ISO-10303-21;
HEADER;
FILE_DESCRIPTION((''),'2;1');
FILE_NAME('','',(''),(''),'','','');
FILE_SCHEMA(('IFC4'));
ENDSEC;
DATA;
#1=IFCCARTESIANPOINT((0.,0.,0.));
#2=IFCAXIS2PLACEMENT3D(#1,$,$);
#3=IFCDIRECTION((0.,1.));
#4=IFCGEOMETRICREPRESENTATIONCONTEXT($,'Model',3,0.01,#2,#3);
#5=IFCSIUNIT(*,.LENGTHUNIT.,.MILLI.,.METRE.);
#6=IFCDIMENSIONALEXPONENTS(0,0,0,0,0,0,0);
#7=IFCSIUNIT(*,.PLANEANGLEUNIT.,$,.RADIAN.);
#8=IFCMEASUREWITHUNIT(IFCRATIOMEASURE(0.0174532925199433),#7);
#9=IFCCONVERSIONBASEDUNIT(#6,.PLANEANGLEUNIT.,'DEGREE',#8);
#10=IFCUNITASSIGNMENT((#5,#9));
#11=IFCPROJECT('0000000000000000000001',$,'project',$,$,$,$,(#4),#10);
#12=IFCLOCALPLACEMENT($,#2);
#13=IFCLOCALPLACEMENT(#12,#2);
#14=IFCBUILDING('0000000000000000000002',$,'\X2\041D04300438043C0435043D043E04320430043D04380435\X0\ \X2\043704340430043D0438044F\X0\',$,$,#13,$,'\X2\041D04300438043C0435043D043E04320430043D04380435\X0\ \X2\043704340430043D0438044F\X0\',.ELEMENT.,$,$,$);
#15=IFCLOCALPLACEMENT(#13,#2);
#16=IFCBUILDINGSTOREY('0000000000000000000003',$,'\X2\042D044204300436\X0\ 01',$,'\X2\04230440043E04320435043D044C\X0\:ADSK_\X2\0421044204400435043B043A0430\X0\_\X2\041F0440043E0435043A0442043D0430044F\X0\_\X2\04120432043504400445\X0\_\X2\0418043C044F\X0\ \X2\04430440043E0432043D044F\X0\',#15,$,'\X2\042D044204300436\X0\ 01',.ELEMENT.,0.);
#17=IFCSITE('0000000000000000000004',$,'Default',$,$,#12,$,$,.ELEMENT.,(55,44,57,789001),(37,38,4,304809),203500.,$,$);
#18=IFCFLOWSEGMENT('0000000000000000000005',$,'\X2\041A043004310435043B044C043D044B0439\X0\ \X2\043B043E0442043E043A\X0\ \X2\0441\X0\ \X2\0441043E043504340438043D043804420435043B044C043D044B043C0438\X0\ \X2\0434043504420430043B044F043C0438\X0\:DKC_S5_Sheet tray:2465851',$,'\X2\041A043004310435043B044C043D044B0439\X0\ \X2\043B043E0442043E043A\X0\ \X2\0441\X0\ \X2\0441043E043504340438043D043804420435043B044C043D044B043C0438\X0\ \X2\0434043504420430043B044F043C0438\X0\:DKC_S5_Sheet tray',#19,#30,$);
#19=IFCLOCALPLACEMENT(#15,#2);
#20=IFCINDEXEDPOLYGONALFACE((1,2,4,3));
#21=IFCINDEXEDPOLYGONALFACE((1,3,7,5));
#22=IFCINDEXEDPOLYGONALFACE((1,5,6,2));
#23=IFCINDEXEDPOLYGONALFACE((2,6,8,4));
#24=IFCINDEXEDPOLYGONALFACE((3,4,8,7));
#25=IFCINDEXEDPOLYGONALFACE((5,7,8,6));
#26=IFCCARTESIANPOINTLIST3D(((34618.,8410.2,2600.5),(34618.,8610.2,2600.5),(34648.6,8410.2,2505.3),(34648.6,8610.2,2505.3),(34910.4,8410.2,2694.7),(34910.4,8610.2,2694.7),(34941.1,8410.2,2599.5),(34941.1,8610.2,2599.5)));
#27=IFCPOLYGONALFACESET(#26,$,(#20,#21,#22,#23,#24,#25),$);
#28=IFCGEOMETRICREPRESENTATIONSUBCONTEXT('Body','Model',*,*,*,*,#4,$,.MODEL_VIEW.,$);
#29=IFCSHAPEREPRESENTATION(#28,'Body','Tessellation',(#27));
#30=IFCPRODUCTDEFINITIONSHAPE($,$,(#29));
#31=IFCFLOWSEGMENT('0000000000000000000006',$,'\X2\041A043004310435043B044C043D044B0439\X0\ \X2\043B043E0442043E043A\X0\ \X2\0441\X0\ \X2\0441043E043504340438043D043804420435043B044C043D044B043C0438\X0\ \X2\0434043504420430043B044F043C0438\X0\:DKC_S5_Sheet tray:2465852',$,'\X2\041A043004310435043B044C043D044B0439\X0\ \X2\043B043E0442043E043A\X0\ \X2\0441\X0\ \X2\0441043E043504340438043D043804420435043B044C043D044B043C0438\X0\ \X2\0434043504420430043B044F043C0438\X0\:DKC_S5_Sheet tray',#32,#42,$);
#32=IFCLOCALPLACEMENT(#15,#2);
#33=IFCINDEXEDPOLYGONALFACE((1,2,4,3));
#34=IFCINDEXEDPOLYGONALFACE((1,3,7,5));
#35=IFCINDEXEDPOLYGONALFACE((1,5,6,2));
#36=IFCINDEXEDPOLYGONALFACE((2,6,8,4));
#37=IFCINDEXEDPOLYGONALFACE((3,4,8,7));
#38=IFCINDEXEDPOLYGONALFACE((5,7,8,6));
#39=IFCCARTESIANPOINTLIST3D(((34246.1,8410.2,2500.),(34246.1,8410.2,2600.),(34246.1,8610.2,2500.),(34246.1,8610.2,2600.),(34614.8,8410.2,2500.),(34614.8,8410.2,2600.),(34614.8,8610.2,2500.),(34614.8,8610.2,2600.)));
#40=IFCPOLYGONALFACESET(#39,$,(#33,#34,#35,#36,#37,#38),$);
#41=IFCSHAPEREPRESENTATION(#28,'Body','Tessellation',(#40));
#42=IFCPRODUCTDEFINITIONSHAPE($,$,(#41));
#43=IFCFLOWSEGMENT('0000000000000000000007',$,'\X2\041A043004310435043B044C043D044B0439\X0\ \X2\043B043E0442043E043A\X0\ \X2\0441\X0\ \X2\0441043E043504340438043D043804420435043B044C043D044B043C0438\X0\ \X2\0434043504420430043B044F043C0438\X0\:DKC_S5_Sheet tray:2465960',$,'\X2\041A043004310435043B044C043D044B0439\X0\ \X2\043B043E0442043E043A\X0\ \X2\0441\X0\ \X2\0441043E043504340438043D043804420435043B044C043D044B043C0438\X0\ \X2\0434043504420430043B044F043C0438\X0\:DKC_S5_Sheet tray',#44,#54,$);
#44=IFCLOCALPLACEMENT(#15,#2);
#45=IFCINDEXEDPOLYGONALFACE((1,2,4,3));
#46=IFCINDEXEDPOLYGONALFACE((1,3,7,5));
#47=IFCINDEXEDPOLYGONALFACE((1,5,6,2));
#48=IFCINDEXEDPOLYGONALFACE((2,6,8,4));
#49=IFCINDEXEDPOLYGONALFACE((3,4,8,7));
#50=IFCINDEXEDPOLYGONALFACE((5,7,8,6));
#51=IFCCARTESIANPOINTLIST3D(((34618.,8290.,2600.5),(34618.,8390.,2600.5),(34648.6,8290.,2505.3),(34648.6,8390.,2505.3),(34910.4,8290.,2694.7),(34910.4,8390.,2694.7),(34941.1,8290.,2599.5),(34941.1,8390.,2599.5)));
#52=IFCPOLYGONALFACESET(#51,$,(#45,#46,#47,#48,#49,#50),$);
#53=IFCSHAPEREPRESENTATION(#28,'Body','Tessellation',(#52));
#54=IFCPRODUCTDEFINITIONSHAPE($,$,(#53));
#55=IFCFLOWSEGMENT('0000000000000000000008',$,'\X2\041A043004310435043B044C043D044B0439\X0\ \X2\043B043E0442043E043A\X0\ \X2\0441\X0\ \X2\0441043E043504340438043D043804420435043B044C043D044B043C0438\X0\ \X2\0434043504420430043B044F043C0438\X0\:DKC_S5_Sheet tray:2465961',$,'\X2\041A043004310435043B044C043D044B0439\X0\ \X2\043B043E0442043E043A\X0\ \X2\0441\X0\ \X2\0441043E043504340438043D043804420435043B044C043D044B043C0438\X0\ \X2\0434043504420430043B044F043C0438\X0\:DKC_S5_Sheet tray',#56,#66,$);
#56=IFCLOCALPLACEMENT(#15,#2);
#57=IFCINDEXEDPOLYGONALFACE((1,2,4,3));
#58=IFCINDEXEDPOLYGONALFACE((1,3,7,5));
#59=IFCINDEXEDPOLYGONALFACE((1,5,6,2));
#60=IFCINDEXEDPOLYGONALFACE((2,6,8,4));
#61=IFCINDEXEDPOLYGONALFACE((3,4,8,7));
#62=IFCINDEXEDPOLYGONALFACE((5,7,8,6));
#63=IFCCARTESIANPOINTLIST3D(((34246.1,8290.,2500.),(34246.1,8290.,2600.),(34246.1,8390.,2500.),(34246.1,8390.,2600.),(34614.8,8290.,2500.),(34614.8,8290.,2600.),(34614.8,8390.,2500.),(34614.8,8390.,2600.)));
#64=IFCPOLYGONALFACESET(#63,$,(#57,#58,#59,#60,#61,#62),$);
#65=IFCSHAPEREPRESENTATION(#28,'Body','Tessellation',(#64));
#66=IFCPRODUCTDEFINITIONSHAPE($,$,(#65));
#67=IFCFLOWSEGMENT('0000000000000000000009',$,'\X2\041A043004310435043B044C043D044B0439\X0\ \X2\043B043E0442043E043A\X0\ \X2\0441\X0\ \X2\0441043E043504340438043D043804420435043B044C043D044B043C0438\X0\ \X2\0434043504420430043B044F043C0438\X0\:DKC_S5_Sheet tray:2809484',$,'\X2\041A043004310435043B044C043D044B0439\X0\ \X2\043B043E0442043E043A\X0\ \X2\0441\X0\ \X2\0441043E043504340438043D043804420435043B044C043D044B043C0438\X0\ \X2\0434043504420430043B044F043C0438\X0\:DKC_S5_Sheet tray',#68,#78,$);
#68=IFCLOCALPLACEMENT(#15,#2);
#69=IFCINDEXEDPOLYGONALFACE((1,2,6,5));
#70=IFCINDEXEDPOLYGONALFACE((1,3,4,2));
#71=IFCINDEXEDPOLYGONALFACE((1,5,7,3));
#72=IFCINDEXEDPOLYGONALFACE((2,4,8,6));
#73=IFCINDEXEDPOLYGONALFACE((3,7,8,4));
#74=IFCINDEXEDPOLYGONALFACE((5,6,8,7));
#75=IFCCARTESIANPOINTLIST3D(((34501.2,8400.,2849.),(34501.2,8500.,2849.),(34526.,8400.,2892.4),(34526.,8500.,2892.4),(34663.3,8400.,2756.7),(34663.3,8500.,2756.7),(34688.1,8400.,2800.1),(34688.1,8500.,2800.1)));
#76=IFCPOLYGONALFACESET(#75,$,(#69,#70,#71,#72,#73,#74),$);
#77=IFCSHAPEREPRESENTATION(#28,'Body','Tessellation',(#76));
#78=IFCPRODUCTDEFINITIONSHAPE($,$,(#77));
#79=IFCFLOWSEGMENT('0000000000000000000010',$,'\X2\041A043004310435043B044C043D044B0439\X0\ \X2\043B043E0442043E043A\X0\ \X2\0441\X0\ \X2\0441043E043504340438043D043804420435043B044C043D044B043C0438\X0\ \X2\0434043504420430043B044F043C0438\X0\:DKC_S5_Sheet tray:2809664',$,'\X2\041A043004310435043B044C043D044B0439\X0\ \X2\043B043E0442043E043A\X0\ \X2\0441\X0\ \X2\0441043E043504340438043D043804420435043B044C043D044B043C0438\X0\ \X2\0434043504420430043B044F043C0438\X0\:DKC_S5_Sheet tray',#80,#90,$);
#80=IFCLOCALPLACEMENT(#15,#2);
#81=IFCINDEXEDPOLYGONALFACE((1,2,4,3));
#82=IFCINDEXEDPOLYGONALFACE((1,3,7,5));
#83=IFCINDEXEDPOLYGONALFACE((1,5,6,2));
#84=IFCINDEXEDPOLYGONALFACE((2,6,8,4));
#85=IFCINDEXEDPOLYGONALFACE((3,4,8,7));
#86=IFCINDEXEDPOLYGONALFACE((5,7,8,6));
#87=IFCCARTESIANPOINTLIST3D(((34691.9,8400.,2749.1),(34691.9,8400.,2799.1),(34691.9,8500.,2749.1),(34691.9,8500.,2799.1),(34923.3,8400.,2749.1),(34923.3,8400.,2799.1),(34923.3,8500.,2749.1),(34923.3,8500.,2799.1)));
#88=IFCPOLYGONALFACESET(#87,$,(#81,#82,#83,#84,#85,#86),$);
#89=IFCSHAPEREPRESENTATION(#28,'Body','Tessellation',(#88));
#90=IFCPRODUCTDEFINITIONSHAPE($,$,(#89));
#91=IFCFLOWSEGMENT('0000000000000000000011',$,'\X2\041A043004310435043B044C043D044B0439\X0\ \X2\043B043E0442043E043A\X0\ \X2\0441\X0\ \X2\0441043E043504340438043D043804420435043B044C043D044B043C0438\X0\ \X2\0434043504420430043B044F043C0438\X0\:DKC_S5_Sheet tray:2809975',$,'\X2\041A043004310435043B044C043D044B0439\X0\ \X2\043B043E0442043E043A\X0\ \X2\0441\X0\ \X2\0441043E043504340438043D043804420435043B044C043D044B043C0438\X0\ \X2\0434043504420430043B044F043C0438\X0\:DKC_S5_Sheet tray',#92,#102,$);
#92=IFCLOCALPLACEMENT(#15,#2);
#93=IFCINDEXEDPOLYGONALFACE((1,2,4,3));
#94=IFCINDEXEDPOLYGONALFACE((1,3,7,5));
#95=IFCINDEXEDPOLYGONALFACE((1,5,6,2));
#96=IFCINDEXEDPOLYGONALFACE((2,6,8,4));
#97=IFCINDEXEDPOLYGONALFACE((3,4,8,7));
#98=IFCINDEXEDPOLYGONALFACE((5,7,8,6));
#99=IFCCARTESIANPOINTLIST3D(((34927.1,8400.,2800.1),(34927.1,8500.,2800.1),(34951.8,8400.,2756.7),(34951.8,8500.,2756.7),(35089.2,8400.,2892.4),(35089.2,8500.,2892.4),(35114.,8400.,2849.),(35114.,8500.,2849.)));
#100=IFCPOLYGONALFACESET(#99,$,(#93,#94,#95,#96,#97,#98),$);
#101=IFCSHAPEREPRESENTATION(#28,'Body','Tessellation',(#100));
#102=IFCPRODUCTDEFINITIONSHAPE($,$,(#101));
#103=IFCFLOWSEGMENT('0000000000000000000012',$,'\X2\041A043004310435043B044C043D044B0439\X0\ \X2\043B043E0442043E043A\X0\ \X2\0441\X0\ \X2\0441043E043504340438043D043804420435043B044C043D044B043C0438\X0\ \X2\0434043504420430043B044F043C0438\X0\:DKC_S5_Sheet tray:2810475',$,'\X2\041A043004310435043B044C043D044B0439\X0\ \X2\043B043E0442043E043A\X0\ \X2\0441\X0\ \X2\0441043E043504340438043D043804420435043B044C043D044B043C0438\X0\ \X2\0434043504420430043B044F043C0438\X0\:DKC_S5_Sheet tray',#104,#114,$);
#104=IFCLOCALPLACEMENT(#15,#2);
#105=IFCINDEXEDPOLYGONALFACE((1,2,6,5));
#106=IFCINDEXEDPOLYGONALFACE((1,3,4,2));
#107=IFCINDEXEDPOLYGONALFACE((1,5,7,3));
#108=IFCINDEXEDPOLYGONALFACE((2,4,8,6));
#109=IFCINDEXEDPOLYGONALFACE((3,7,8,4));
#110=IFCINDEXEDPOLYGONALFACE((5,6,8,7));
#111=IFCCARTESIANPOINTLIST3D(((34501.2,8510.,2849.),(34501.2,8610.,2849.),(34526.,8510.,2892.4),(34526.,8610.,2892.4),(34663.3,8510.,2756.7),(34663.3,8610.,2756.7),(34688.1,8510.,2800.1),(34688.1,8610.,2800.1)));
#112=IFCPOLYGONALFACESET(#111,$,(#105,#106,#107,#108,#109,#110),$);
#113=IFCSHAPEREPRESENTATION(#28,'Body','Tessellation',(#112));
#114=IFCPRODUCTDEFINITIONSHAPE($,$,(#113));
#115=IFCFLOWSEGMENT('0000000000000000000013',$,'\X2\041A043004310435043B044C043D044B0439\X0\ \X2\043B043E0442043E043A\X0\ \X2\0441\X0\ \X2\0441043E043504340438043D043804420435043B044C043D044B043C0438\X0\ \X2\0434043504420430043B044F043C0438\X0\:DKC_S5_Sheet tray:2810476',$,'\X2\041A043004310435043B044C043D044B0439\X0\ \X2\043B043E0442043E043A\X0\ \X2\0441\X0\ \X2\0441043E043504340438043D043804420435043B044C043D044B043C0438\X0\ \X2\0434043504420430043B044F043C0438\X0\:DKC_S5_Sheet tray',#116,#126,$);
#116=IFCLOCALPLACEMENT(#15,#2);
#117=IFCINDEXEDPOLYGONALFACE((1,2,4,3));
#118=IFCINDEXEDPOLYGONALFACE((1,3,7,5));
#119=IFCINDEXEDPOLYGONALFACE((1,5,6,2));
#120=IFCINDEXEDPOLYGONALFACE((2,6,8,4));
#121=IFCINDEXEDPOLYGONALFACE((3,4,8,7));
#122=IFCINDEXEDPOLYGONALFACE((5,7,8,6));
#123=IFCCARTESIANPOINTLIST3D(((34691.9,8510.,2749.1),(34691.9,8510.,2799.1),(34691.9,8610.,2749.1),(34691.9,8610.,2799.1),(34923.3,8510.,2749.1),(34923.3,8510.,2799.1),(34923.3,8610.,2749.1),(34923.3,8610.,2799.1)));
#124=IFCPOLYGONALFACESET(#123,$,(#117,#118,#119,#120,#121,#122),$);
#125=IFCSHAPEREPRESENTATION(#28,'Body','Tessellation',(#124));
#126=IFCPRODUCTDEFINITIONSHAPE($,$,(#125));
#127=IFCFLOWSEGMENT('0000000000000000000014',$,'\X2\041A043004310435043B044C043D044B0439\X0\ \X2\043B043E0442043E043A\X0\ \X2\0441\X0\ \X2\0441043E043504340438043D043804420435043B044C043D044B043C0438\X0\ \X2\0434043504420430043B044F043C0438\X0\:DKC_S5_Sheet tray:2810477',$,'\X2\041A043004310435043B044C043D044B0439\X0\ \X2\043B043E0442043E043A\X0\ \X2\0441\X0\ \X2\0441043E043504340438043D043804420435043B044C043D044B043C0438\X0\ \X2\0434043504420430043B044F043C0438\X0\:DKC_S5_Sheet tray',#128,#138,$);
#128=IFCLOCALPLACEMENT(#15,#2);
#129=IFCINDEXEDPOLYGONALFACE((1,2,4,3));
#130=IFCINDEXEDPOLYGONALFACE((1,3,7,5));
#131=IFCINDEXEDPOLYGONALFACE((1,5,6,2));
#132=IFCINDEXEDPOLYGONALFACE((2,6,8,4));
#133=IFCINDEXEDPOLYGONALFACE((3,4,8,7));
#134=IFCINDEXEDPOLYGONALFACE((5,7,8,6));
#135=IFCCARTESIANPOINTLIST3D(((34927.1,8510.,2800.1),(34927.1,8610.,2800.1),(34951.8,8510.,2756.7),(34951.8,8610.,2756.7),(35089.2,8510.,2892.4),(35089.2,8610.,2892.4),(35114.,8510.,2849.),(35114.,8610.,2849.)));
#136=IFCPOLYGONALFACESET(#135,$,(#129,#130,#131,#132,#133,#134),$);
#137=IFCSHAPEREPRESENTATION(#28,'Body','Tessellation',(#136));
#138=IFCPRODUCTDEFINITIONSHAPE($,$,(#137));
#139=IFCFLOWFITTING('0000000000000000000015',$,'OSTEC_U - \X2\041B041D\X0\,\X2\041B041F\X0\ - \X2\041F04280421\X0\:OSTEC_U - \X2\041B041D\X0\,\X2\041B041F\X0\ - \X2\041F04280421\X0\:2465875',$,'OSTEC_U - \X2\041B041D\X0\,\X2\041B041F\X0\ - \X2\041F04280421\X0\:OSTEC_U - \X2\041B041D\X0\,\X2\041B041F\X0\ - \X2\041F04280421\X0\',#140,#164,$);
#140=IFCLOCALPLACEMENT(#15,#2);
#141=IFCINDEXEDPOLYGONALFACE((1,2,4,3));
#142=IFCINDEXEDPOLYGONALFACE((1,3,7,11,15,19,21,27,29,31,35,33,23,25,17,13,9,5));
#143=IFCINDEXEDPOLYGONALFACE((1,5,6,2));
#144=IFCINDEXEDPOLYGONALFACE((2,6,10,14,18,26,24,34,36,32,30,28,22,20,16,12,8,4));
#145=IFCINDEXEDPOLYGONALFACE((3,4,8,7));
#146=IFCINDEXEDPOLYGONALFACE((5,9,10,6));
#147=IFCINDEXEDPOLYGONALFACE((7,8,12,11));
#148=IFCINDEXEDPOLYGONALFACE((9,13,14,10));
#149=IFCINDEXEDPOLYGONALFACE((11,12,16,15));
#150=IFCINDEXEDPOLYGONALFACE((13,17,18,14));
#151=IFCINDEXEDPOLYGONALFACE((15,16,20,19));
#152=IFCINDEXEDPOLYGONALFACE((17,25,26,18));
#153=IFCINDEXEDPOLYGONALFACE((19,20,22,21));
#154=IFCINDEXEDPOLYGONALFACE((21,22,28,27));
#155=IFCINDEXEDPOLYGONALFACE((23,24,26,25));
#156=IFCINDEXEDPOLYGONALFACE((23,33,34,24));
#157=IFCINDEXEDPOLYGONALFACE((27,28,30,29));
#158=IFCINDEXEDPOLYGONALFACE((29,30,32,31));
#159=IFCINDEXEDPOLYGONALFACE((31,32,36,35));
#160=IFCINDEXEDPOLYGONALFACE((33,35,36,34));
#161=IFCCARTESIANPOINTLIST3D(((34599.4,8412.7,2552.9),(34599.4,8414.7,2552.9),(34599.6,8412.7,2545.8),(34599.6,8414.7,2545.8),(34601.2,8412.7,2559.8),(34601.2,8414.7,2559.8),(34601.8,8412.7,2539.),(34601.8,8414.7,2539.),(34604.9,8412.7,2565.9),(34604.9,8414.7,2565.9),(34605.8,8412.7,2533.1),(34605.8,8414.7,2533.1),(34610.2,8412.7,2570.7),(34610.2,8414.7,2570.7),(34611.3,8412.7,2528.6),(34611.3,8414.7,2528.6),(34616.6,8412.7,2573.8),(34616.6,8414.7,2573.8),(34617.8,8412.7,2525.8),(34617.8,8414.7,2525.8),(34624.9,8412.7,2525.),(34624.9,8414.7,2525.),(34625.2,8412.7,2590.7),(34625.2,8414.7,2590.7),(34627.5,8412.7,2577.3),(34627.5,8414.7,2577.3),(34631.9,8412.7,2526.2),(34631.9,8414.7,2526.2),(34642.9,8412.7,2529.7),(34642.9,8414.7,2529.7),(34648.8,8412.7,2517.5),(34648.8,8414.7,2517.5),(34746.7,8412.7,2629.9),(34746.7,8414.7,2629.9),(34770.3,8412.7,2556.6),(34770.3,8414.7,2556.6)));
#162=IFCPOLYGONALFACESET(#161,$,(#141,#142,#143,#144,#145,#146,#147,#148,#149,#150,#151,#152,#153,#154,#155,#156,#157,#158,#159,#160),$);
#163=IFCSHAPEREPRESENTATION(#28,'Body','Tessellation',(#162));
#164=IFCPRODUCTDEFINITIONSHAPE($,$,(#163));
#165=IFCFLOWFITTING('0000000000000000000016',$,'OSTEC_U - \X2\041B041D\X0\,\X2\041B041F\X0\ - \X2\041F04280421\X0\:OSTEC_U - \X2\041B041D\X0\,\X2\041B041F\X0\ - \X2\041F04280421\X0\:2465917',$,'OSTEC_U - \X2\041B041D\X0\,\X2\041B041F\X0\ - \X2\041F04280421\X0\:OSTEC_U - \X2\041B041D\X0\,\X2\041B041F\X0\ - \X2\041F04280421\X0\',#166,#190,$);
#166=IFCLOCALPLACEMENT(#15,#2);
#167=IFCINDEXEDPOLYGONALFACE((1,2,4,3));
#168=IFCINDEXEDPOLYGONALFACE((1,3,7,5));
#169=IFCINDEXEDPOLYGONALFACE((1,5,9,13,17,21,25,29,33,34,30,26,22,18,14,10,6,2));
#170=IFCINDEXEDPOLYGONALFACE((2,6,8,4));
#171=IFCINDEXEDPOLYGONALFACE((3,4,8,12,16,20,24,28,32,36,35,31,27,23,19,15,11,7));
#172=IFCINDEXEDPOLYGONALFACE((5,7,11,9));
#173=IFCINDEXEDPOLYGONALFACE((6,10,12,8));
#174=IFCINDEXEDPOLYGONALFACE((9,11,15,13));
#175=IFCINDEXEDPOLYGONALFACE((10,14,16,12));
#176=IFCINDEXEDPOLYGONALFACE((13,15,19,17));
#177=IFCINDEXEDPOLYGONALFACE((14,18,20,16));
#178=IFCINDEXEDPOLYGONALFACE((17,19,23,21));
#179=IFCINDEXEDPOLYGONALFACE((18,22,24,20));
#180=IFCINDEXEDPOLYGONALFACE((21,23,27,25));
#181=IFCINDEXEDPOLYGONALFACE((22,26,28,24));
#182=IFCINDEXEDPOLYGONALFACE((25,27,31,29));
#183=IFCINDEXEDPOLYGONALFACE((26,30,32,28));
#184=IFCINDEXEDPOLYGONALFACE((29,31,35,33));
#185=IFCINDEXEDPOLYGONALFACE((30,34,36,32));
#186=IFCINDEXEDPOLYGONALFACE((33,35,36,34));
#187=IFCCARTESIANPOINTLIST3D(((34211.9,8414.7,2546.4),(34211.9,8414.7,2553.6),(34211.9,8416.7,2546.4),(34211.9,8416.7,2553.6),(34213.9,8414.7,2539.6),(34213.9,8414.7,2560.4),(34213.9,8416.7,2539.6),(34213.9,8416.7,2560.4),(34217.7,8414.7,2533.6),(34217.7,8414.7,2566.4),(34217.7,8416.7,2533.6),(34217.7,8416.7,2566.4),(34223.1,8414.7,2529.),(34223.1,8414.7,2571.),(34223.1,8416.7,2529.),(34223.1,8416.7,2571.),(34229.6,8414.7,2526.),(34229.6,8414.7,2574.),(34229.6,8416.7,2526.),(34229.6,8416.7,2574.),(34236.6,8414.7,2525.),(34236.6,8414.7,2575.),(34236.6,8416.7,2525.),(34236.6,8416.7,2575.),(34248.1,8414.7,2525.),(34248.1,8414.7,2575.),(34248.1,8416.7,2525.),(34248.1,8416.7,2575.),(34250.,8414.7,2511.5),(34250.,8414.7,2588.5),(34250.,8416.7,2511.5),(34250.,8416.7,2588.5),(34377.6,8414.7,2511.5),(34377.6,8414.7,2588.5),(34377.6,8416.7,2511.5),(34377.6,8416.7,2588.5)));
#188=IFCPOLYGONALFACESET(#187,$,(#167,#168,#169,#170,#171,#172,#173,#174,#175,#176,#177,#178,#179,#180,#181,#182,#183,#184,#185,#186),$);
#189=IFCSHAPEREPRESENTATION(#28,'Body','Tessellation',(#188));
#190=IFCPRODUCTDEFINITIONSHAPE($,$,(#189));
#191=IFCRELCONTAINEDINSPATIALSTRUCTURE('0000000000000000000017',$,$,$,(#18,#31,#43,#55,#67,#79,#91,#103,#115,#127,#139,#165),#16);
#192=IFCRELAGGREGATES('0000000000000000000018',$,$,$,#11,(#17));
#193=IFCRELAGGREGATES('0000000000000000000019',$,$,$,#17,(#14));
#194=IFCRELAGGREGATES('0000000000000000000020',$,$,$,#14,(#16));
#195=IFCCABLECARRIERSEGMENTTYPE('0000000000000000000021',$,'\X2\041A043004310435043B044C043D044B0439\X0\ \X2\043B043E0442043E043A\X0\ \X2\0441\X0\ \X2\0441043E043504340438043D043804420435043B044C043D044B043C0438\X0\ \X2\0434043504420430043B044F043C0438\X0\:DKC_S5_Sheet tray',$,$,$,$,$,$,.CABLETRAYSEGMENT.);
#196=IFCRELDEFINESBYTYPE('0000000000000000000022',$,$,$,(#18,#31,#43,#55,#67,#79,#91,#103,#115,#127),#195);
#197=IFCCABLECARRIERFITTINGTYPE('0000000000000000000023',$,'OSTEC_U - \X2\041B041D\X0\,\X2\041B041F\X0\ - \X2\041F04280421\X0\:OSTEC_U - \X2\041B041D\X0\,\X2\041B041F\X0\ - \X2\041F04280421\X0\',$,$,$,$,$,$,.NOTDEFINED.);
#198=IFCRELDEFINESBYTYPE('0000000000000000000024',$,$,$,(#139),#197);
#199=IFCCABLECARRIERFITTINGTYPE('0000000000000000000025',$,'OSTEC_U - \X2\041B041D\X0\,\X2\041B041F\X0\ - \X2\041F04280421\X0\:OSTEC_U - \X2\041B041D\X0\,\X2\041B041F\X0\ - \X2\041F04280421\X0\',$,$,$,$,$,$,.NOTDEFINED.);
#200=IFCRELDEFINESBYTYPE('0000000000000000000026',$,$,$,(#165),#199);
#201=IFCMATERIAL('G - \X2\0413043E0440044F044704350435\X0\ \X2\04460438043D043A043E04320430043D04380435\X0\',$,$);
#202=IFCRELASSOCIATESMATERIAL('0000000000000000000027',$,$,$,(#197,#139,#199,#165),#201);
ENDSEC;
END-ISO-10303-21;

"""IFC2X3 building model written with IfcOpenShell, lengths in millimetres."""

from ifc_helpers import new_model, entity, si_unit, converted_unit, direction, frame, frame_2d, origin, origin_2d_with_axis, place, context, subcontext, project, spatial, polyline, circle_curve, parameter, trimmed, segment, composite_curve, rectangle, outline, extrude, source, transform, mapped, material, type_object, type_shapes, element, save


model = new_model("IFC2X3")

# Units and contexts
model_context = context("Model", 3, precision=0.01, world=origin(), true_north=direction((0.0, 1.0)))
body_context = subcontext(model_context, "Body", "Model", "MODEL_VIEW")
ifc_project = project(units=[si_unit("LENGTHUNIT", "METRE", prefix="MILLI"), converted_unit("PLANEANGLEUNIT", "DEGREE", entity("IfcRatioMeasure", 0.0174532925199433), si_unit("PLANEANGLEUNIT", "RADIAN"), dimensions=[0, 0, 0, 0, 0, 0, 0])], contexts=[model_context])

# Site, building, storey
site_placement = place(None, origin())
site = spatial("IfcSite", under=ifc_project, at=site_placement, Name="Default", CompositionType="ELEMENT", RefLatitude=(55, 44, 57, 789001), RefLongitude=(37, 38, 4, 304809), RefElevation=203500.0)
building_placement = place(site_placement, origin())
building = spatial("IfcBuilding", under=site, at=building_placement, Name="Наименование здания", LongName="Наименование здания", CompositionType="ELEMENT")
storey_placement = place(building_placement, origin())
storey = spatial("IfcBuildingStorey", under=building, at=storey_placement, Name="Этаж 01", ObjectType="Уровень:ADSK_Стрелка_Проектная_Вверх_Имя уровня", LongName="Этаж 01", CompositionType="ELEMENT", Elevation=0.0)

# Flow segments
cable_carrier_segment_type = type_object("IfcCableCarrierSegmentType", Name="Кабельный лоток с соединительными деталями:DKC_S5_Sheet tray", PredefinedType="CABLETRAYSEGMENT")
flow_segment_1_placement = place(storey_placement, frame((34617.9, 8410.2, 2505.3)))
element("IfcFlowSegment", 1, at=flow_segment_1_placement, inside=storey, type_object=cable_carrier_segment_type, Name="Кабельный лоток с соединительными деталями:DKC_S5_Sheet tray:2465851", ObjectType="Кабельный лоток с соединительными деталями:DKC_S5_Sheet tray", context=body_context, shape_type="SweptSolid", body=[
    extrude(rectangle(XDim=100.0, YDim=200.0, at=origin_2d_with_axis()), frame((15.3, 100.0, 47.6), z_axis=(0.951851, 0.0, 0.30656), x_axis=(-0.30656, 0.0, 0.951851)), (0.0, 0.0, 1.0), 307.2),
])
flow_segment_2_placement = place(storey_placement, frame((34246.1, 8410.2, 2500.0)))
element("IfcFlowSegment", 2, at=flow_segment_2_placement, inside=storey, type_object=cable_carrier_segment_type, Name="Кабельный лоток с соединительными деталями:DKC_S5_Sheet tray:2465852", ObjectType="Кабельный лоток с соединительными деталями:DKC_S5_Sheet tray", context=body_context, shape_type="SweptSolid", body=[
    extrude(rectangle(XDim=368.7, YDim=200.0, at=origin_2d_with_axis()), frame((184.3, 100.0, 0.0), z_axis=(0.0, 0.0, 1.0), x_axis=(-1.0, 0.0, 0.0)), (0.0, 0.0, 1.0), 100.0),
])
flow_segment_3_placement = place(storey_placement, frame((34617.9, 8290.0, 2505.3)))
element("IfcFlowSegment", 3, at=flow_segment_3_placement, inside=storey, type_object=cable_carrier_segment_type, Name="Кабельный лоток с соединительными деталями:DKC_S5_Sheet tray:2465960", ObjectType="Кабельный лоток с соединительными деталями:DKC_S5_Sheet tray", context=body_context, shape_type="SweptSolid", body=[
    extrude(rectangle(XDim=100.0, YDim=100.0, at=origin_2d_with_axis()), frame((15.3, 50.0, 47.6), z_axis=(0.951851, 0.0, 0.30656), x_axis=(-0.30656, 0.0, 0.951851)), (0.0, 0.0, 1.0), 307.2),
])
flow_segment_4_placement = place(storey_placement, frame((34246.1, 8290.0, 2500.0)))
element("IfcFlowSegment", 4, at=flow_segment_4_placement, inside=storey, type_object=cable_carrier_segment_type, Name="Кабельный лоток с соединительными деталями:DKC_S5_Sheet tray:2465961", ObjectType="Кабельный лоток с соединительными деталями:DKC_S5_Sheet tray", context=body_context, shape_type="SweptSolid", body=[
    extrude(rectangle(XDim=368.7, YDim=100.0, at=origin_2d_with_axis()), frame((184.3, 50.0, 0.0), z_axis=(0.0, 0.0, 1.0), x_axis=(-1.0, 0.0, 0.0)), (0.0, 0.0, 1.0), 100.0),
])
flow_segment_5_placement = place(storey_placement, frame((34501.2, 8400.0, 2756.7)))
element("IfcFlowSegment", 5, at=flow_segment_5_placement, inside=storey, type_object=cable_carrier_segment_type, Name="Кабельный лоток с соединительными деталями:DKC_S5_Sheet tray:2809484", ObjectType="Кабельный лоток с соединительными деталями:DKC_S5_Sheet tray", context=body_context, shape_type="SweptSolid", body=[
    extrude(rectangle(XDim=50.0, YDim=100.0, at=frame_2d((0.0, 0.0), x_axis=(0.0, 1.0))), frame((12.4, 50.0, 114.0), z_axis=(0.869016, 0.0, -0.494783), x_axis=(0.0, 1.0, 0.0)), (0.0, 0.0, 1.0), 186.6),
])
flow_segment_6_placement = place(storey_placement, frame((34691.9, 8400.0, 2749.1)))
element("IfcFlowSegment", 6, at=flow_segment_6_placement, inside=storey, type_object=cable_carrier_segment_type, Name="Кабельный лоток с соединительными деталями:DKC_S5_Sheet tray:2809664", ObjectType="Кабельный лоток с соединительными деталями:DKC_S5_Sheet tray", context=body_context, shape_type="SweptSolid", body=[
    extrude(rectangle(XDim=231.3, YDim=100.0, at=origin_2d_with_axis()), frame((115.7, 50.0, 0.0)), (0.0, 0.0, 1.0), 50.0),
])
flow_segment_7_placement = place(storey_placement, frame((34927.1, 8400.0, 2756.7)))
element("IfcFlowSegment", 7, at=flow_segment_7_placement, inside=storey, type_object=cable_carrier_segment_type, Name="Кабельный лоток с соединительными деталями:DKC_S5_Sheet tray:2809975", ObjectType="Кабельный лоток с соединительными деталями:DKC_S5_Sheet tray", context=body_context, shape_type="SweptSolid", body=[
    extrude(rectangle(XDim=50.0, YDim=100.0, at=origin_2d_with_axis()), frame((12.4, 50.0, 21.7), z_axis=(0.869016, 0.0, 0.494783), x_axis=(-0.494783, 0.0, 0.869016)), (0.0, 0.0, 1.0), 186.6),
])
flow_segment_8_placement = place(storey_placement, frame((34501.2, 8510.0, 2756.7)))
element("IfcFlowSegment", 8, at=flow_segment_8_placement, inside=storey, type_object=cable_carrier_segment_type, Name="Кабельный лоток с соединительными деталями:DKC_S5_Sheet tray:2810475", ObjectType="Кабельный лоток с соединительными деталями:DKC_S5_Sheet tray", context=body_context, shape_type="SweptSolid", body=[
    extrude(rectangle(XDim=50.0, YDim=100.0, at=frame_2d((0.0, 0.0), x_axis=(0.0, 1.0))), frame((12.4, 50.0, 114.0), z_axis=(0.869016, 0.0, -0.494783), x_axis=(0.0, 1.0, 0.0)), (0.0, 0.0, 1.0), 186.6),
])
flow_segment_9_placement = place(storey_placement, frame((34691.9, 8510.0, 2749.1)))
element("IfcFlowSegment", 9, at=flow_segment_9_placement, inside=storey, type_object=cable_carrier_segment_type, Name="Кабельный лоток с соединительными деталями:DKC_S5_Sheet tray:2810476", ObjectType="Кабельный лоток с соединительными деталями:DKC_S5_Sheet tray", context=body_context, shape_type="SweptSolid", body=[
    extrude(rectangle(XDim=231.3, YDim=100.0, at=origin_2d_with_axis()), frame((115.7, 50.0, 0.0)), (0.0, 0.0, 1.0), 50.0),
])
flow_segment_10_placement = place(storey_placement, frame((34927.1, 8510.0, 2756.7)))
element("IfcFlowSegment", 10, at=flow_segment_10_placement, inside=storey, type_object=cable_carrier_segment_type, Name="Кабельный лоток с соединительными деталями:DKC_S5_Sheet tray:2810477", ObjectType="Кабельный лоток с соединительными деталями:DKC_S5_Sheet tray", context=body_context, shape_type="SweptSolid", body=[
    extrude(rectangle(XDim=50.0, YDim=100.0, at=origin_2d_with_axis()), frame((12.4, 50.0, 21.7), z_axis=(0.869016, 0.0, 0.494783), x_axis=(-0.494783, 0.0, 0.869016)), (0.0, 0.0, 1.0), 186.6),
])

# Flow fittings
ifc_material = material(Name="G - Горячее цинкование")
cable_carrier_fitting_type_1 = type_object("IfcCableCarrierFittingType", Name="OSTEC_U - ЛН,ЛП - ПШС:OSTEC_U - ЛН,ЛП - ПШС", PredefinedType="NOTDEFINED", material=ifc_material)
shared_shape_1 = source(origin(), body_context, "Body", "SweptSolid", [
    extrude(outline(composite_curve([segment(trimmed(circle_curve(frame_2d((-41.5, 0.0), x_axis=(1.0, 0.0)), 25.0), [parameter(90.0)], [parameter(270.0)], True, "PARAMETER"), True, "CONTINUOUS"), segment(polyline([(-41.5, -25.0), (-30.0, -25.0)]), True, "CONTINUOUS"), segment(polyline([(-30.0, -25.0), (-28.1, -38.5)]), True, "CONTINUOUS"), segment(polyline([(-28.1, -38.5), (99.5, -38.5)]), True, "CONTINUOUS"), segment(polyline([(99.5, -38.5), (99.5, 38.5)]), True, "CONTINUOUS"), segment(polyline([(99.5, 38.5), (-28.1, 38.5)]), True, "CONTINUOUS"), segment(polyline([(-28.1, 38.5), (-30.0, 25.0)]), True, "CONTINUOUS"), segment(polyline([(-30.0, 25.0), (-41.5, 25.0)]), True, "CONTINUOUS")], self_intersect=False)), frame((41.5, 0.0, 0.0), z_axis=(0.0, 0.0, -1.0), x_axis=(1.0, 0.0, 0.0)), (0.0, 0.0, -1.0), 2.0),
])
type_shapes(cable_carrier_fitting_type_1, [shared_shape_1])
flow_fitting_1_placement = place(storey_placement, frame((34624.2, 8414.7, 2550.0), z_axis=(0.0, -1.0, 0.0), x_axis=(0.951851, 0.0, 0.30656)))
element("IfcFlowFitting", 11, at=flow_fitting_1_placement, inside=storey, type_object=cable_carrier_fitting_type_1, material=ifc_material, Name="OSTEC_U - ЛН,ЛП - ПШС:OSTEC_U - ЛН,ЛП - ПШС:2465875", ObjectType="OSTEC_U - ЛН,ЛП - ПШС:OSTEC_U - ЛН,ЛП - ПШС", context=body_context, shape_type="MappedRepresentation", body=[
    mapped(shared_shape_1, transform((0.0, 0.0, 0.0), scale=1.0)),
])
cable_carrier_fitting_type_2 = type_object("IfcCableCarrierFittingType", Name="OSTEC_U - ЛН,ЛП - ПШС:OSTEC_U - ЛН,ЛП - ПШС", PredefinedType="NOTDEFINED", material=ifc_material)
type_shapes(cable_carrier_fitting_type_2, [shared_shape_1])
flow_fitting_2_placement = place(storey_placement, frame((34236.6, 8416.7, 2550.0), z_axis=(0.0, -1.0, 0.0), x_axis=(1.0, 0.0, 0.0)))
element("IfcFlowFitting", 12, at=flow_fitting_2_placement, inside=storey, type_object=cable_carrier_fitting_type_2, material=ifc_material, Name="OSTEC_U - ЛН,ЛП - ПШС:OSTEC_U - ЛН,ЛП - ПШС:2465917", ObjectType="OSTEC_U - ЛН,ЛП - ПШС:OSTEC_U - ЛН,ЛП - ПШС", context=body_context, shape_type="MappedRepresentation", body=[
    mapped(shared_shape_1, transform((0.0, 0.0, 0.0), scale=1.0)),
])

save(model, "model.ifc")
